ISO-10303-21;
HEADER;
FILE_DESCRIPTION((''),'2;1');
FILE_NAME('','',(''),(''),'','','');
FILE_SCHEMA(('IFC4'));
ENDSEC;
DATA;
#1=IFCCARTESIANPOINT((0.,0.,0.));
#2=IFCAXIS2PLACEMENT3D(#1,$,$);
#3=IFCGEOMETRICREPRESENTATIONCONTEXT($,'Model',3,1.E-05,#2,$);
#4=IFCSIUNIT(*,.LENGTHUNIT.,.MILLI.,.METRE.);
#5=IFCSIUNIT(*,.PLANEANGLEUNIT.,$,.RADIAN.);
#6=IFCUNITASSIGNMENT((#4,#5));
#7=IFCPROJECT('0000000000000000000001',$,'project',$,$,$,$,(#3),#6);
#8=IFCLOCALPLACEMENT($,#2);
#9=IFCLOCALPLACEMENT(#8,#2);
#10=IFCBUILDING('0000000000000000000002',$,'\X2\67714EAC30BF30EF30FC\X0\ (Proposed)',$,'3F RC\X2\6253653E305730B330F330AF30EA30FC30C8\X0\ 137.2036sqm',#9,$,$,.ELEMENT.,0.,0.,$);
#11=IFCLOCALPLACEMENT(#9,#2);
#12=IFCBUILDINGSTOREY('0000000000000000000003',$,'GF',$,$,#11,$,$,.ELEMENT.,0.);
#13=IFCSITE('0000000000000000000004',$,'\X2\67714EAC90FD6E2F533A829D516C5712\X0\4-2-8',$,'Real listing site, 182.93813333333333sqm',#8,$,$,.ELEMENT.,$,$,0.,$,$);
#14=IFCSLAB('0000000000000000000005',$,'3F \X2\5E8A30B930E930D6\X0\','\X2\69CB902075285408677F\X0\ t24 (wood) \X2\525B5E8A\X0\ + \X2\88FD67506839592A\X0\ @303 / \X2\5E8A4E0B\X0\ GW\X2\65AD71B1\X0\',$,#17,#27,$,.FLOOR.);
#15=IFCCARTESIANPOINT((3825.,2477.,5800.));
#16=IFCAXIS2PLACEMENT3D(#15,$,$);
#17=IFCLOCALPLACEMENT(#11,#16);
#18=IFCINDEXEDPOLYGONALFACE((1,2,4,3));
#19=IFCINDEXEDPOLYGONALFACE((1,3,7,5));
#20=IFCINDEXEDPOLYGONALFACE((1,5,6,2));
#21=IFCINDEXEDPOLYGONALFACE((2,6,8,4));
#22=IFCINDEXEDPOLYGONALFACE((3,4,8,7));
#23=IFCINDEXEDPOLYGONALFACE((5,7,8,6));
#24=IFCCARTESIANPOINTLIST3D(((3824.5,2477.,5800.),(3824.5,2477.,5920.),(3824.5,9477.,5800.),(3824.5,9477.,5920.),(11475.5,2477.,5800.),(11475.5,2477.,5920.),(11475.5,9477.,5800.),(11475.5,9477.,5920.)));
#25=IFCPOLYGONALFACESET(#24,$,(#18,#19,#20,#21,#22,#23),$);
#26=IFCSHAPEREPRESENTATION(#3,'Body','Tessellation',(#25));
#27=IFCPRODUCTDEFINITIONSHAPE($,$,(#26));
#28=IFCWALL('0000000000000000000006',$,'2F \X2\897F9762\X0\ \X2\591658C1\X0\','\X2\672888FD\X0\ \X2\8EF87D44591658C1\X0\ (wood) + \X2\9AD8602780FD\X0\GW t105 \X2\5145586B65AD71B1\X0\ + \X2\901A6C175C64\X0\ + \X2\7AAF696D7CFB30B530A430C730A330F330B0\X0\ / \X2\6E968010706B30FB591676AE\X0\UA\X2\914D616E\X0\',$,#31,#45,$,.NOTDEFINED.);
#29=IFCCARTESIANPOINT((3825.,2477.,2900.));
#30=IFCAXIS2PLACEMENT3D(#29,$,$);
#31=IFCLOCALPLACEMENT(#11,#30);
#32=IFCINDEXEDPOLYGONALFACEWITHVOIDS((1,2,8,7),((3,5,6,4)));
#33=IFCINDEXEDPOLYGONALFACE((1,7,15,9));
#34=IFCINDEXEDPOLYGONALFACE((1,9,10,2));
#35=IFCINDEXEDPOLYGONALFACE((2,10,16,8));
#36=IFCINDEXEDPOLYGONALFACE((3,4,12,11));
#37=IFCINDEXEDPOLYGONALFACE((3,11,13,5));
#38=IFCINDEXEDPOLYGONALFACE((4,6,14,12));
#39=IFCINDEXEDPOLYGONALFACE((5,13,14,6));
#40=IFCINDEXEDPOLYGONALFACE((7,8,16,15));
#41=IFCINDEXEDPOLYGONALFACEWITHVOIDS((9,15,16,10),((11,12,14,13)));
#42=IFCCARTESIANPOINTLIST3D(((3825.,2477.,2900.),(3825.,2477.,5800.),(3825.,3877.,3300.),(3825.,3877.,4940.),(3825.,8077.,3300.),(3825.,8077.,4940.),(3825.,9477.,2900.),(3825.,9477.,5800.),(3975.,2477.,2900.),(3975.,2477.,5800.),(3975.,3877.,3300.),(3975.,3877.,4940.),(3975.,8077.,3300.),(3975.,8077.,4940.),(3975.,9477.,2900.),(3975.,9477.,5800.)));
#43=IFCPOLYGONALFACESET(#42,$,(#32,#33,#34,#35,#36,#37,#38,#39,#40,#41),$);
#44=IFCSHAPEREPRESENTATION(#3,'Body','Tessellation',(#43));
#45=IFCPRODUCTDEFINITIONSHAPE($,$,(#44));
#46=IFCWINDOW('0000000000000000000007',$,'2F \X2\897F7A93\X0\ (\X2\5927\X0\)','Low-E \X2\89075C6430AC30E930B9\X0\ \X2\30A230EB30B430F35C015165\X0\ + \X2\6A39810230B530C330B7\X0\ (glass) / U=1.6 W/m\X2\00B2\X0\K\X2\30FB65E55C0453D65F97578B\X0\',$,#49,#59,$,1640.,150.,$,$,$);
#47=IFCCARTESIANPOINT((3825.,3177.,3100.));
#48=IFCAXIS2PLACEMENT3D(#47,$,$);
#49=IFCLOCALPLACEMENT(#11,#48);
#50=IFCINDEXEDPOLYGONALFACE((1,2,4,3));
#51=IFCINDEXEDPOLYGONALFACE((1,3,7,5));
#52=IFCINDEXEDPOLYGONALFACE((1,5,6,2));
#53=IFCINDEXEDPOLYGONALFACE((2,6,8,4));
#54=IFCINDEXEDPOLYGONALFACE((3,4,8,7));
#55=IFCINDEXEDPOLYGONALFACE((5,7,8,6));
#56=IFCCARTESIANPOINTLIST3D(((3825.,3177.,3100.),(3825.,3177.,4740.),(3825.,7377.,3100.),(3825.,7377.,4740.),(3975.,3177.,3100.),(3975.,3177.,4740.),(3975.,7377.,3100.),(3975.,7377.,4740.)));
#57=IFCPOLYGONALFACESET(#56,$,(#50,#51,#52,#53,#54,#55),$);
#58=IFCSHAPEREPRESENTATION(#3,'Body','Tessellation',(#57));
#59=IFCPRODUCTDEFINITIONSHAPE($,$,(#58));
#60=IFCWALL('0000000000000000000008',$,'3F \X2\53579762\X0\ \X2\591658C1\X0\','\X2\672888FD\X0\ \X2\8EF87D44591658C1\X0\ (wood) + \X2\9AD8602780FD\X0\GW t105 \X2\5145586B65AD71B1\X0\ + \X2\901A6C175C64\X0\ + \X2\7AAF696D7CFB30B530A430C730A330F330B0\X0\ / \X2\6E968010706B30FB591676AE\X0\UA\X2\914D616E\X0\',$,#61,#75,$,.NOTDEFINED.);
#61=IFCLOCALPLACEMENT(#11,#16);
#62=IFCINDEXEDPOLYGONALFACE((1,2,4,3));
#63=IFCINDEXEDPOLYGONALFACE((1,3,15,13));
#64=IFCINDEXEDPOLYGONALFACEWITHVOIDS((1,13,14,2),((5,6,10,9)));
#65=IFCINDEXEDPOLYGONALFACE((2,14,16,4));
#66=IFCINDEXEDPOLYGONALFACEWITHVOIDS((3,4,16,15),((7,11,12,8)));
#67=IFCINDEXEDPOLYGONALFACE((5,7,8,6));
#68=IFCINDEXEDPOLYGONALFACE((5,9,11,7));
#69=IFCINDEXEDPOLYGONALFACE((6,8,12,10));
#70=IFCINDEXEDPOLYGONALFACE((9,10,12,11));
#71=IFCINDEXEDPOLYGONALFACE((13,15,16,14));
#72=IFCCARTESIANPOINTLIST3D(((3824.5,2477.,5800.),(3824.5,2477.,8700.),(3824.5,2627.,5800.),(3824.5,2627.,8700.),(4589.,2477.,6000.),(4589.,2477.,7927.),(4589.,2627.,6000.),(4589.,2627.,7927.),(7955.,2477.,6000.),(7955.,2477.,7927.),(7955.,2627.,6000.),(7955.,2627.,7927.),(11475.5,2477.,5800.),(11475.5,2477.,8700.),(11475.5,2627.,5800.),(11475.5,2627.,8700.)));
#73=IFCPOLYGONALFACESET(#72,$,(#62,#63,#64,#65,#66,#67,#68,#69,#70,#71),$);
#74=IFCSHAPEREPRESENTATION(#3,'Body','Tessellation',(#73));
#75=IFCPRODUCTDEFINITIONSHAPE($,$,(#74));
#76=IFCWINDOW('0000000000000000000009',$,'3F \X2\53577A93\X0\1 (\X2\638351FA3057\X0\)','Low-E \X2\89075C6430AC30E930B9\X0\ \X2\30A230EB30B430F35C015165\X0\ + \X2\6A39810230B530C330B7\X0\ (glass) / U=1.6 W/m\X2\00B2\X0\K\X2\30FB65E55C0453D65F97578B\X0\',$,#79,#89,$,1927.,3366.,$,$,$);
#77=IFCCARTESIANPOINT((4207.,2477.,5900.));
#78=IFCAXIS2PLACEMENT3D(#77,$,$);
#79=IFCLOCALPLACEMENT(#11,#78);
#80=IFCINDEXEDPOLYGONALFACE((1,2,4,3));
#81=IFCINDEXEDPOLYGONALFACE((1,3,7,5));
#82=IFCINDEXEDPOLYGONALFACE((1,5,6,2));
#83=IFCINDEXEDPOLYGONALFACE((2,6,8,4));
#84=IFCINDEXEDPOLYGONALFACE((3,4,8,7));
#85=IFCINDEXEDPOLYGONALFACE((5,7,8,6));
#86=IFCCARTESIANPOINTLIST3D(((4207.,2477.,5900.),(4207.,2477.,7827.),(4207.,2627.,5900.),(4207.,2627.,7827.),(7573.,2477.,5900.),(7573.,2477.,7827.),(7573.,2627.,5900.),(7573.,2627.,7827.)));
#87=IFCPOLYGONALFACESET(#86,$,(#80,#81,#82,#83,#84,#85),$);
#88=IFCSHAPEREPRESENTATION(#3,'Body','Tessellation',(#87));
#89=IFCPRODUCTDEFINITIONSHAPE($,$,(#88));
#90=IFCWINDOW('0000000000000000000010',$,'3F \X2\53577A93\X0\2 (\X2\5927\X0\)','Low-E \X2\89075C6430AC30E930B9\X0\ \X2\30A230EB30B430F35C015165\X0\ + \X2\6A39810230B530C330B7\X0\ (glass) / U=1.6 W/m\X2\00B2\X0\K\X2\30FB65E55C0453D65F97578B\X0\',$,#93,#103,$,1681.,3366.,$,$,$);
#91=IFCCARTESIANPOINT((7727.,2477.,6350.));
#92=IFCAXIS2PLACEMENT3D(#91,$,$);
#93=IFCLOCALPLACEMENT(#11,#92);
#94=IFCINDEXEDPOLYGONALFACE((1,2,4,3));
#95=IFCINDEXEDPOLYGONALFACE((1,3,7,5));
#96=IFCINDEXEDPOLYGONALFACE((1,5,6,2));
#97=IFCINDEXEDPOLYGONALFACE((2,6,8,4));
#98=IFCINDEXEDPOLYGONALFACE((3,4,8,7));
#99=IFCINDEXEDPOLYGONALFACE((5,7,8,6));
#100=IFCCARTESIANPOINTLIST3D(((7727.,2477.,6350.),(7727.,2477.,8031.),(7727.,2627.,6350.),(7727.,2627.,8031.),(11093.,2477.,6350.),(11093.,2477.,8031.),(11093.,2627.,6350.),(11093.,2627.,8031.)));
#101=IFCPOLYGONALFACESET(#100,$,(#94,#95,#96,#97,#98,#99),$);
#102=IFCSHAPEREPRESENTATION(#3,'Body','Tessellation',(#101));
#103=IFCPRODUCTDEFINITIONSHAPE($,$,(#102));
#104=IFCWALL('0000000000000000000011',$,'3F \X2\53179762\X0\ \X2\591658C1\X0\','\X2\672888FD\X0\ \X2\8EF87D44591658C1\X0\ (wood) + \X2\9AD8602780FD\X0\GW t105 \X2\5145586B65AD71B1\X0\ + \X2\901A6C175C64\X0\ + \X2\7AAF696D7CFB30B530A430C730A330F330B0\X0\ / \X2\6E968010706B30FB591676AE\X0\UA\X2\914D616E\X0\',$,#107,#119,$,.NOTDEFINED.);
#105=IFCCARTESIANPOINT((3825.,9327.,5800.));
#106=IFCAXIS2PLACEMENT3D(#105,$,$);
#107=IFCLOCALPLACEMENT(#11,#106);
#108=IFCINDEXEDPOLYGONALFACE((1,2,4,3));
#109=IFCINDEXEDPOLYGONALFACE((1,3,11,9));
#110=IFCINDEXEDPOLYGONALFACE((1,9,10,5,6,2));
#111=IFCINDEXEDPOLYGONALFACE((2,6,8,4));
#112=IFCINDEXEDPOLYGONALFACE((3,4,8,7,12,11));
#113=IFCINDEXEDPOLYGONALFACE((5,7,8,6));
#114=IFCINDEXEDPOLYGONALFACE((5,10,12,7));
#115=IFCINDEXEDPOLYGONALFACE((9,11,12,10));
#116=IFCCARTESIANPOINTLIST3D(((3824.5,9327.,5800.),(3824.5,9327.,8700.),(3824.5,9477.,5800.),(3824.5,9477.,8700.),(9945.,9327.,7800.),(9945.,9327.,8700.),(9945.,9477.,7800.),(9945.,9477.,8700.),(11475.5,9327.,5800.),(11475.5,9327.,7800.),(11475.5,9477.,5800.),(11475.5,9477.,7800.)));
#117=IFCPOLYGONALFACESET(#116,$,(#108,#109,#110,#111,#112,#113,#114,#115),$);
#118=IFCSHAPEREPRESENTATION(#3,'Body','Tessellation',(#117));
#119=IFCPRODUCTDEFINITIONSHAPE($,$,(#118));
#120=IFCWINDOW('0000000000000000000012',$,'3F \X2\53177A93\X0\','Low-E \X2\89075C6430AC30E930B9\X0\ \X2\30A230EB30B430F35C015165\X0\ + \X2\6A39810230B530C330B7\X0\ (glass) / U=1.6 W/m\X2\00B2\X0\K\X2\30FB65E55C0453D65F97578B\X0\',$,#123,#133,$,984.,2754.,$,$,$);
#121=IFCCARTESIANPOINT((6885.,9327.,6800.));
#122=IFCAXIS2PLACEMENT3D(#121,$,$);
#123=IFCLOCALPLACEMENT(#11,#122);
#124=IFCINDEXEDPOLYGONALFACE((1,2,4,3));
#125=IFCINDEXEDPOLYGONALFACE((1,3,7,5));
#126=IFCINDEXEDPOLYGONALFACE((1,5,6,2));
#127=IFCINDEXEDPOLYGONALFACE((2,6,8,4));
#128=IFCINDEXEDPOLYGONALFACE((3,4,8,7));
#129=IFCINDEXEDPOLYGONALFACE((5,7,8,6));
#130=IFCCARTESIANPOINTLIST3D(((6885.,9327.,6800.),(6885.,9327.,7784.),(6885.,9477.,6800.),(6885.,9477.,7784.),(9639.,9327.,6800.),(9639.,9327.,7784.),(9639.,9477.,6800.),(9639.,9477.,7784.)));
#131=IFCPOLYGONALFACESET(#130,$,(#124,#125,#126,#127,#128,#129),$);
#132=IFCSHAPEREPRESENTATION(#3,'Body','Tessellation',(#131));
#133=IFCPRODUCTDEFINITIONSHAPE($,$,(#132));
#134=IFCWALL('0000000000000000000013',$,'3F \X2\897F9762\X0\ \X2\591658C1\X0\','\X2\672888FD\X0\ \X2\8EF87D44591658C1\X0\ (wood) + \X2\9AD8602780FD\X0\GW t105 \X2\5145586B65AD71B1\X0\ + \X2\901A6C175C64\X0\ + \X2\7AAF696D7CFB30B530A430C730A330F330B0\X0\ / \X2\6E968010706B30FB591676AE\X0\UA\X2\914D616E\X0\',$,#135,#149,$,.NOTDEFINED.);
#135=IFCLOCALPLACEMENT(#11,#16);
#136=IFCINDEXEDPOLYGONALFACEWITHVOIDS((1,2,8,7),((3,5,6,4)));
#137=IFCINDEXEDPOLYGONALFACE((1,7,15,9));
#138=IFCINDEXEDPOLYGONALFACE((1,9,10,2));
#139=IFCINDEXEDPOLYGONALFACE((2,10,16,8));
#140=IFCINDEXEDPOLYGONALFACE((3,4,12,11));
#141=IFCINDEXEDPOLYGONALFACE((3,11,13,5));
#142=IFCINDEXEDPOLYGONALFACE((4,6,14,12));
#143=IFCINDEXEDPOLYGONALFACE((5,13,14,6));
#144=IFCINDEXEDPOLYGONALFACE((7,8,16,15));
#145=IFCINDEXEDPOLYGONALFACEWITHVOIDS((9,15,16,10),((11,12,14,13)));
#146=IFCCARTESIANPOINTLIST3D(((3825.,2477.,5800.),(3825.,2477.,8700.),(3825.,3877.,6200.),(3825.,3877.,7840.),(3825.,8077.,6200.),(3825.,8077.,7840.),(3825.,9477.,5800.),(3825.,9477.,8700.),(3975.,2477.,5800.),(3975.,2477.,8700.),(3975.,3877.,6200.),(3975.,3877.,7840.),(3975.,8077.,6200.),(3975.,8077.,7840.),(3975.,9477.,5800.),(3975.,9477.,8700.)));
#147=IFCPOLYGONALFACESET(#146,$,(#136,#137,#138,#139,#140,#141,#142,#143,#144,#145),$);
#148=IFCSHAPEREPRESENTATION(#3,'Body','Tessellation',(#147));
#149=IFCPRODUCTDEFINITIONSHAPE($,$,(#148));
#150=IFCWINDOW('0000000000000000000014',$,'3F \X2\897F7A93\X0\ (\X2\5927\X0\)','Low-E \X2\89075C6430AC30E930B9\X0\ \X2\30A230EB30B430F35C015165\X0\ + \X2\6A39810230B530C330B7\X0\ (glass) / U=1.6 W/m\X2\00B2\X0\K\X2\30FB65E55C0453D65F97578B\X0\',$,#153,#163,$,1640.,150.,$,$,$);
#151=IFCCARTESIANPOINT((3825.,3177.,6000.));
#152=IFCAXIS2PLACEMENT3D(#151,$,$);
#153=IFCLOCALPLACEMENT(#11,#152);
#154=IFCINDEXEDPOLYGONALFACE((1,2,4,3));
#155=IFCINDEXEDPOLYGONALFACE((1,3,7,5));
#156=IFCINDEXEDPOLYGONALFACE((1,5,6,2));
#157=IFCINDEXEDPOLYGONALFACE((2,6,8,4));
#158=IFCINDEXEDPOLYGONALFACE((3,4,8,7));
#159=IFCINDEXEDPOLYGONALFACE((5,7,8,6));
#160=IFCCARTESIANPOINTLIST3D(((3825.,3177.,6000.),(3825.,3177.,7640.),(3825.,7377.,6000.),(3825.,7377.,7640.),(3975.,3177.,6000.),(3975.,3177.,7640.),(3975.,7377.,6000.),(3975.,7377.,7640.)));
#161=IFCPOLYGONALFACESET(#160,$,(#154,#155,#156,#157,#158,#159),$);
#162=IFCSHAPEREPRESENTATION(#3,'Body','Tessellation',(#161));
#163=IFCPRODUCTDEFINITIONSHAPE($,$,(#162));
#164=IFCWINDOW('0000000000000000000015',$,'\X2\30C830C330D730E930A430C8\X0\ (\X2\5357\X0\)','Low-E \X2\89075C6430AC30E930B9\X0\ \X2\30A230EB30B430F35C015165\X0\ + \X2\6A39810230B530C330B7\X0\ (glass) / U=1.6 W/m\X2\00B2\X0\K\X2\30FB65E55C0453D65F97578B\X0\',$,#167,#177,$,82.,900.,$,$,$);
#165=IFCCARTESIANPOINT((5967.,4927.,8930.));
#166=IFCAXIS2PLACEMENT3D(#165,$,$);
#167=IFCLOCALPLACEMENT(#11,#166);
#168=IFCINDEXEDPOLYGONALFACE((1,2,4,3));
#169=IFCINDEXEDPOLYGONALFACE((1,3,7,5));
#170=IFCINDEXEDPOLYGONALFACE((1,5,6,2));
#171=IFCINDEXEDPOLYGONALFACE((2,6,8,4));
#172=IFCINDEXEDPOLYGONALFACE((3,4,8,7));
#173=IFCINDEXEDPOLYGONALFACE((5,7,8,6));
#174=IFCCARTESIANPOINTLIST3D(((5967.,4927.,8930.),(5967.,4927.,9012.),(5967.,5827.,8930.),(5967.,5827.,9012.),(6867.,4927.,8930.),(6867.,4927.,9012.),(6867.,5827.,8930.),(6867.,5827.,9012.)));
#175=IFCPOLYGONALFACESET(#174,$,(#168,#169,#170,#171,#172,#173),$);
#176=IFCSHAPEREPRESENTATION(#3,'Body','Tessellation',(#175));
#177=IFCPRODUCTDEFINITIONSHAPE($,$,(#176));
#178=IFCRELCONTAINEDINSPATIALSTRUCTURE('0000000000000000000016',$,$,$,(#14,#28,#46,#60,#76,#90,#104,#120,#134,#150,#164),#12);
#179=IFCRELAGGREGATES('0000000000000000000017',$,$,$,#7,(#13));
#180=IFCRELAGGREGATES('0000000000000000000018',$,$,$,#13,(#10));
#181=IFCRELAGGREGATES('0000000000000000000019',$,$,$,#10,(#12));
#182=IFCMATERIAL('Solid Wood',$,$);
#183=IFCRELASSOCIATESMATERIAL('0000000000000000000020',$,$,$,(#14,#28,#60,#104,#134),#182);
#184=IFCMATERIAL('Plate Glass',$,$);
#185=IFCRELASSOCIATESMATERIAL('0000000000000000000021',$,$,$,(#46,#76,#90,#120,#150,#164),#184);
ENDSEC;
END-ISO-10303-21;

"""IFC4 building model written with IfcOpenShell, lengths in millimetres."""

from ifc_helpers import new_model, si_unit, frame, frame_2d, origin, place, context, project, spatial, rectangle, extrude, material, element, fill, save


model = new_model("IFC4")

# Units and contexts
model_context = context("Model", 3, precision=1e-05, world=origin())
ifc_project = project(units=[si_unit("LENGTHUNIT", "METRE", prefix="MILLI"), si_unit("PLANEANGLEUNIT", "RADIAN")], contexts=[model_context])

# Site, building, storey
site_placement = place(None, origin())
site = spatial("IfcSite", under=ifc_project, at=site_placement, Name="東京都港区芝公園4-2-8", ObjectType="Real listing site, 182.93813333333333sqm", CompositionType="ELEMENT", RefElevation=0.0)
building_placement = place(site_placement, origin())
building = spatial("IfcBuilding", under=site, at=building_placement, Name="東京タワー (Proposed)", ObjectType="3F RC打放しコンクリート 137.2036sqm", CompositionType="ELEMENT", ElevationOfRefHeight=0.0, ElevationOfTerrain=0.0)
storey_placement = place(building_placement, origin())
storey = spatial("IfcBuildingStorey", under=building, at=storey_placement, Name="GF", CompositionType="ELEMENT", Elevation=0.0)

# Slab
ifc_material_1 = material(Name="Solid Wood")
slab_placement = place(storey_placement, frame((3825.0, 2477.0, 5800.0)))
element("IfcSlab", 1, at=slab_placement, inside=storey, material=ifc_material_1, Name="3F 床スラブ", Description="構造用合板 t24 (wood) 剛床 + 製材根太 @303 / 床下 GW断熱", PredefinedType="FLOOR", context=model_context, shape_type="SweptSolid", body=[
    extrude(rectangle(XDim=7651.0, YDim=7000.0, at=frame_2d((3825.0, 3500.0))), frame((3825.0, 2477.0, 5800.0)), (0.0, 0.0, 1.0), 120.0),
])

# Wall, opening, window
wall_1_placement = place(storey_placement, frame((3825.0, 2477.0, 2900.0)))
wall_1 = element("IfcWall", 2, at=wall_1_placement, inside=storey, material=ifc_material_1, Name="2F 西面 外壁", Description="木製 軸組外壁 (wood) + 高性能GW t105 充填断熱 + 通気層 + 窯業系サイディング / 準耐火・外皮UA配慮", PredefinedType="NOTDEFINED", context=model_context, shape_type="SweptSolid", body=[
    extrude(rectangle(XDim=150.0, YDim=7000.0, at=frame_2d((75.0, 3500.0))), frame((3825.0, 2477.0, 2900.0)), (0.0, 0.0, 1.0), 2900.0),
])
opening_1_placement = place(storey_placement, frame((3825.0, 3177.0, 3100.0)))
opening_1 = element("IfcOpeningElement", 3, at=opening_1_placement, cuts=wall_1, PredefinedType="NOTDEFINED", context=model_context, shape_type="SweptSolid", body=[
    extrude(rectangle(XDim=150.0, YDim=4200.0, at=frame_2d((75.0, 2100.0))), frame((3825.0, 3177.0, 3100.0)), (0.0, 0.0, 1.0), 1640.0),
])
ifc_material_2 = material(Name="Plate Glass")
window_1_placement = place(storey_placement, frame((3825.0, 3177.0, 3100.0)))
window_1 = element("IfcWindow", 4, at=window_1_placement, inside=storey, material=ifc_material_2, Name="2F 西窓 (大)", Description="Low-E 複層ガラス アルゴン封入 + 樹脂サッシ (glass) / U=1.6 W/m²K・日射取得型", OverallHeight=1640.0, OverallWidth=150.0, context=model_context, shape_type="SweptSolid", body=[
    extrude(rectangle(XDim=150.0, YDim=4200.0, at=frame_2d((75.0, 2100.0))), frame((3825.0, 3177.0, 3100.0)), (0.0, 0.0, 1.0), 1640.0),
])
fill(opening_1, window_1)

# Wall, openings, windows
wall_2_placement = place(storey_placement, frame((3825.0, 2477.0, 5800.0)))
wall_2 = element("IfcWall", 5, at=wall_2_placement, inside=storey, material=ifc_material_1, Name="3F 南面 外壁", Description="木製 軸組外壁 (wood) + 高性能GW t105 充填断熱 + 通気層 + 窯業系サイディング / 準耐火・外皮UA配慮", PredefinedType="NOTDEFINED", context=model_context, shape_type="SweptSolid", body=[
    extrude(rectangle(XDim=7651.0, YDim=150.0, at=frame_2d((3825.0, 75.0))), frame((3825.0, 2477.0, 5800.0)), (0.0, 0.0, 1.0), 2900.0),
])
opening_2_placement = place(storey_placement, frame((4207.0, 2477.0, 5900.0)))
opening_2 = element("IfcOpeningElement", 6, at=opening_2_placement, cuts=wall_2, PredefinedType="NOTDEFINED", context=model_context, shape_type="SweptSolid", body=[
    extrude(rectangle(XDim=3366.0, YDim=150.0, at=frame_2d((1683.0, 75.0))), frame((4207.0, 2477.0, 5900.0)), (0.0, 0.0, 1.0), 1927.0),
])
opening_3_placement = place(storey_placement, frame((7727.0, 2477.0, 6350.0)))
opening_3 = element("IfcOpeningElement", 7, at=opening_3_placement, cuts=wall_2, PredefinedType="NOTDEFINED", context=model_context, shape_type="SweptSolid", body=[
    extrude(rectangle(XDim=3366.0, YDim=150.0, at=frame_2d((1683.0, 75.0))), frame((7727.0, 2477.0, 6350.0)), (0.0, 0.0, 1.0), 1681.0),
])
window_2_placement = place(storey_placement, frame((4207.0, 2477.0, 5900.0)))
window_2 = element("IfcWindow", 8, at=window_2_placement, inside=storey, material=ifc_material_2, Name="3F 南窓1 (掃出し)", Description="Low-E 複層ガラス アルゴン封入 + 樹脂サッシ (glass) / U=1.6 W/m²K・日射取得型", OverallHeight=1927.0, OverallWidth=3366.0, context=model_context, shape_type="SweptSolid", body=[
    extrude(rectangle(XDim=3366.0, YDim=150.0, at=frame_2d((1683.0, 75.0))), frame((4207.0, 2477.0, 5900.0)), (0.0, 0.0, 1.0), 1927.0),
])
fill(opening_2, window_2)
window_3_placement = place(storey_placement, frame((7727.0, 2477.0, 6350.0)))
window_3 = element("IfcWindow", 9, at=window_3_placement, inside=storey, material=ifc_material_2, Name="3F 南窓2 (大)", Description="Low-E 複層ガラス アルゴン封入 + 樹脂サッシ (glass) / U=1.6 W/m²K・日射取得型", OverallHeight=1681.0, OverallWidth=3366.0, context=model_context, shape_type="SweptSolid", body=[
    extrude(rectangle(XDim=3366.0, YDim=150.0, at=frame_2d((1683.0, 75.0))), frame((7727.0, 2477.0, 6350.0)), (0.0, 0.0, 1.0), 1681.0),
])
fill(opening_3, window_3)

# Walls, openings, windows
wall_3_placement = place(storey_placement, frame((3825.0, 9327.0, 5800.0)))
wall_3 = element("IfcWall", 10, at=wall_3_placement, inside=storey, material=ifc_material_1, Name="3F 北面 外壁", Description="木製 軸組外壁 (wood) + 高性能GW t105 充填断熱 + 通気層 + 窯業系サイディング / 準耐火・外皮UA配慮", PredefinedType="NOTDEFINED", context=model_context, shape_type="SweptSolid", body=[
    extrude(rectangle(XDim=7651.0, YDim=150.0, at=frame_2d((3825.0, 75.0))), frame((3825.0, 9327.0, 5800.0)), (0.0, 0.0, 1.0), 2900.0),
])
opening_4_placement = place(storey_placement, frame((6885.0, 9327.0, 6800.0)))
opening_4 = element("IfcOpeningElement", 11, at=opening_4_placement, cuts=wall_3, PredefinedType="NOTDEFINED", context=model_context, shape_type="SweptSolid", body=[
    extrude(rectangle(XDim=2754.0, YDim=150.0, at=frame_2d((1377.0, 75.0))), frame((6885.0, 9327.0, 6800.0)), (0.0, 0.0, 1.0), 984.0),
])
window_4_placement = place(storey_placement, frame((6885.0, 9327.0, 6800.0)))
window_4 = element("IfcWindow", 12, at=window_4_placement, inside=storey, material=ifc_material_2, Name="3F 北窓", Description="Low-E 複層ガラス アルゴン封入 + 樹脂サッシ (glass) / U=1.6 W/m²K・日射取得型", OverallHeight=984.0, OverallWidth=2754.0, context=model_context, shape_type="SweptSolid", body=[
    extrude(rectangle(XDim=2754.0, YDim=150.0, at=frame_2d((1377.0, 75.0))), frame((6885.0, 9327.0, 6800.0)), (0.0, 0.0, 1.0), 984.0),
])
fill(opening_4, window_4)
wall_4_placement = place(storey_placement, frame((3825.0, 2477.0, 5800.0)))
wall_4 = element("IfcWall", 13, at=wall_4_placement, inside=storey, material=ifc_material_1, Name="3F 西面 外壁", Description="木製 軸組外壁 (wood) + 高性能GW t105 充填断熱 + 通気層 + 窯業系サイディング / 準耐火・外皮UA配慮", PredefinedType="NOTDEFINED", context=model_context, shape_type="SweptSolid", body=[
    extrude(rectangle(XDim=150.0, YDim=7000.0, at=frame_2d((75.0, 3500.0))), frame((3825.0, 2477.0, 5800.0)), (0.0, 0.0, 1.0), 2900.0),
])
opening_5_placement = place(storey_placement, frame((3825.0, 3177.0, 6000.0)))
opening_5 = element("IfcOpeningElement", 14, at=opening_5_placement, cuts=wall_4, PredefinedType="NOTDEFINED", context=model_context, shape_type="SweptSolid", body=[
    extrude(rectangle(XDim=150.0, YDim=4200.0, at=frame_2d((75.0, 2100.0))), frame((3825.0, 3177.0, 6000.0)), (0.0, 0.0, 1.0), 1640.0),
])
window_5_placement = place(storey_placement, frame((3825.0, 3177.0, 6000.0)))
window_5 = element("IfcWindow", 15, at=window_5_placement, inside=storey, material=ifc_material_2, Name="3F 西窓 (大)", Description="Low-E 複層ガラス アルゴン封入 + 樹脂サッシ (glass) / U=1.6 W/m²K・日射取得型", OverallHeight=1640.0, OverallWidth=150.0, context=model_context, shape_type="SweptSolid", body=[
    extrude(rectangle(XDim=150.0, YDim=4200.0, at=frame_2d((75.0, 2100.0))), frame((3825.0, 3177.0, 6000.0)), (0.0, 0.0, 1.0), 1640.0),
])
fill(opening_5, window_5)

# Window
window_6_placement = place(storey_placement, frame((5967.0, 4927.0, 8930.0)))
element("IfcWindow", 16, at=window_6_placement, inside=storey, material=ifc_material_2, Name="トップライト (南)", Description="Low-E 複層ガラス アルゴン封入 + 樹脂サッシ (glass) / U=1.6 W/m²K・日射取得型", OverallHeight=82.0, OverallWidth=900.0, context=model_context, shape_type="SweptSolid", body=[
    extrude(rectangle(XDim=900.0, YDim=900.0, at=frame_2d((450.0, 450.0))), frame((5967.0, 4927.0, 8930.0)), (0.0, 0.0, 1.0), 82.0),
])

save(model, "model.ifc")
